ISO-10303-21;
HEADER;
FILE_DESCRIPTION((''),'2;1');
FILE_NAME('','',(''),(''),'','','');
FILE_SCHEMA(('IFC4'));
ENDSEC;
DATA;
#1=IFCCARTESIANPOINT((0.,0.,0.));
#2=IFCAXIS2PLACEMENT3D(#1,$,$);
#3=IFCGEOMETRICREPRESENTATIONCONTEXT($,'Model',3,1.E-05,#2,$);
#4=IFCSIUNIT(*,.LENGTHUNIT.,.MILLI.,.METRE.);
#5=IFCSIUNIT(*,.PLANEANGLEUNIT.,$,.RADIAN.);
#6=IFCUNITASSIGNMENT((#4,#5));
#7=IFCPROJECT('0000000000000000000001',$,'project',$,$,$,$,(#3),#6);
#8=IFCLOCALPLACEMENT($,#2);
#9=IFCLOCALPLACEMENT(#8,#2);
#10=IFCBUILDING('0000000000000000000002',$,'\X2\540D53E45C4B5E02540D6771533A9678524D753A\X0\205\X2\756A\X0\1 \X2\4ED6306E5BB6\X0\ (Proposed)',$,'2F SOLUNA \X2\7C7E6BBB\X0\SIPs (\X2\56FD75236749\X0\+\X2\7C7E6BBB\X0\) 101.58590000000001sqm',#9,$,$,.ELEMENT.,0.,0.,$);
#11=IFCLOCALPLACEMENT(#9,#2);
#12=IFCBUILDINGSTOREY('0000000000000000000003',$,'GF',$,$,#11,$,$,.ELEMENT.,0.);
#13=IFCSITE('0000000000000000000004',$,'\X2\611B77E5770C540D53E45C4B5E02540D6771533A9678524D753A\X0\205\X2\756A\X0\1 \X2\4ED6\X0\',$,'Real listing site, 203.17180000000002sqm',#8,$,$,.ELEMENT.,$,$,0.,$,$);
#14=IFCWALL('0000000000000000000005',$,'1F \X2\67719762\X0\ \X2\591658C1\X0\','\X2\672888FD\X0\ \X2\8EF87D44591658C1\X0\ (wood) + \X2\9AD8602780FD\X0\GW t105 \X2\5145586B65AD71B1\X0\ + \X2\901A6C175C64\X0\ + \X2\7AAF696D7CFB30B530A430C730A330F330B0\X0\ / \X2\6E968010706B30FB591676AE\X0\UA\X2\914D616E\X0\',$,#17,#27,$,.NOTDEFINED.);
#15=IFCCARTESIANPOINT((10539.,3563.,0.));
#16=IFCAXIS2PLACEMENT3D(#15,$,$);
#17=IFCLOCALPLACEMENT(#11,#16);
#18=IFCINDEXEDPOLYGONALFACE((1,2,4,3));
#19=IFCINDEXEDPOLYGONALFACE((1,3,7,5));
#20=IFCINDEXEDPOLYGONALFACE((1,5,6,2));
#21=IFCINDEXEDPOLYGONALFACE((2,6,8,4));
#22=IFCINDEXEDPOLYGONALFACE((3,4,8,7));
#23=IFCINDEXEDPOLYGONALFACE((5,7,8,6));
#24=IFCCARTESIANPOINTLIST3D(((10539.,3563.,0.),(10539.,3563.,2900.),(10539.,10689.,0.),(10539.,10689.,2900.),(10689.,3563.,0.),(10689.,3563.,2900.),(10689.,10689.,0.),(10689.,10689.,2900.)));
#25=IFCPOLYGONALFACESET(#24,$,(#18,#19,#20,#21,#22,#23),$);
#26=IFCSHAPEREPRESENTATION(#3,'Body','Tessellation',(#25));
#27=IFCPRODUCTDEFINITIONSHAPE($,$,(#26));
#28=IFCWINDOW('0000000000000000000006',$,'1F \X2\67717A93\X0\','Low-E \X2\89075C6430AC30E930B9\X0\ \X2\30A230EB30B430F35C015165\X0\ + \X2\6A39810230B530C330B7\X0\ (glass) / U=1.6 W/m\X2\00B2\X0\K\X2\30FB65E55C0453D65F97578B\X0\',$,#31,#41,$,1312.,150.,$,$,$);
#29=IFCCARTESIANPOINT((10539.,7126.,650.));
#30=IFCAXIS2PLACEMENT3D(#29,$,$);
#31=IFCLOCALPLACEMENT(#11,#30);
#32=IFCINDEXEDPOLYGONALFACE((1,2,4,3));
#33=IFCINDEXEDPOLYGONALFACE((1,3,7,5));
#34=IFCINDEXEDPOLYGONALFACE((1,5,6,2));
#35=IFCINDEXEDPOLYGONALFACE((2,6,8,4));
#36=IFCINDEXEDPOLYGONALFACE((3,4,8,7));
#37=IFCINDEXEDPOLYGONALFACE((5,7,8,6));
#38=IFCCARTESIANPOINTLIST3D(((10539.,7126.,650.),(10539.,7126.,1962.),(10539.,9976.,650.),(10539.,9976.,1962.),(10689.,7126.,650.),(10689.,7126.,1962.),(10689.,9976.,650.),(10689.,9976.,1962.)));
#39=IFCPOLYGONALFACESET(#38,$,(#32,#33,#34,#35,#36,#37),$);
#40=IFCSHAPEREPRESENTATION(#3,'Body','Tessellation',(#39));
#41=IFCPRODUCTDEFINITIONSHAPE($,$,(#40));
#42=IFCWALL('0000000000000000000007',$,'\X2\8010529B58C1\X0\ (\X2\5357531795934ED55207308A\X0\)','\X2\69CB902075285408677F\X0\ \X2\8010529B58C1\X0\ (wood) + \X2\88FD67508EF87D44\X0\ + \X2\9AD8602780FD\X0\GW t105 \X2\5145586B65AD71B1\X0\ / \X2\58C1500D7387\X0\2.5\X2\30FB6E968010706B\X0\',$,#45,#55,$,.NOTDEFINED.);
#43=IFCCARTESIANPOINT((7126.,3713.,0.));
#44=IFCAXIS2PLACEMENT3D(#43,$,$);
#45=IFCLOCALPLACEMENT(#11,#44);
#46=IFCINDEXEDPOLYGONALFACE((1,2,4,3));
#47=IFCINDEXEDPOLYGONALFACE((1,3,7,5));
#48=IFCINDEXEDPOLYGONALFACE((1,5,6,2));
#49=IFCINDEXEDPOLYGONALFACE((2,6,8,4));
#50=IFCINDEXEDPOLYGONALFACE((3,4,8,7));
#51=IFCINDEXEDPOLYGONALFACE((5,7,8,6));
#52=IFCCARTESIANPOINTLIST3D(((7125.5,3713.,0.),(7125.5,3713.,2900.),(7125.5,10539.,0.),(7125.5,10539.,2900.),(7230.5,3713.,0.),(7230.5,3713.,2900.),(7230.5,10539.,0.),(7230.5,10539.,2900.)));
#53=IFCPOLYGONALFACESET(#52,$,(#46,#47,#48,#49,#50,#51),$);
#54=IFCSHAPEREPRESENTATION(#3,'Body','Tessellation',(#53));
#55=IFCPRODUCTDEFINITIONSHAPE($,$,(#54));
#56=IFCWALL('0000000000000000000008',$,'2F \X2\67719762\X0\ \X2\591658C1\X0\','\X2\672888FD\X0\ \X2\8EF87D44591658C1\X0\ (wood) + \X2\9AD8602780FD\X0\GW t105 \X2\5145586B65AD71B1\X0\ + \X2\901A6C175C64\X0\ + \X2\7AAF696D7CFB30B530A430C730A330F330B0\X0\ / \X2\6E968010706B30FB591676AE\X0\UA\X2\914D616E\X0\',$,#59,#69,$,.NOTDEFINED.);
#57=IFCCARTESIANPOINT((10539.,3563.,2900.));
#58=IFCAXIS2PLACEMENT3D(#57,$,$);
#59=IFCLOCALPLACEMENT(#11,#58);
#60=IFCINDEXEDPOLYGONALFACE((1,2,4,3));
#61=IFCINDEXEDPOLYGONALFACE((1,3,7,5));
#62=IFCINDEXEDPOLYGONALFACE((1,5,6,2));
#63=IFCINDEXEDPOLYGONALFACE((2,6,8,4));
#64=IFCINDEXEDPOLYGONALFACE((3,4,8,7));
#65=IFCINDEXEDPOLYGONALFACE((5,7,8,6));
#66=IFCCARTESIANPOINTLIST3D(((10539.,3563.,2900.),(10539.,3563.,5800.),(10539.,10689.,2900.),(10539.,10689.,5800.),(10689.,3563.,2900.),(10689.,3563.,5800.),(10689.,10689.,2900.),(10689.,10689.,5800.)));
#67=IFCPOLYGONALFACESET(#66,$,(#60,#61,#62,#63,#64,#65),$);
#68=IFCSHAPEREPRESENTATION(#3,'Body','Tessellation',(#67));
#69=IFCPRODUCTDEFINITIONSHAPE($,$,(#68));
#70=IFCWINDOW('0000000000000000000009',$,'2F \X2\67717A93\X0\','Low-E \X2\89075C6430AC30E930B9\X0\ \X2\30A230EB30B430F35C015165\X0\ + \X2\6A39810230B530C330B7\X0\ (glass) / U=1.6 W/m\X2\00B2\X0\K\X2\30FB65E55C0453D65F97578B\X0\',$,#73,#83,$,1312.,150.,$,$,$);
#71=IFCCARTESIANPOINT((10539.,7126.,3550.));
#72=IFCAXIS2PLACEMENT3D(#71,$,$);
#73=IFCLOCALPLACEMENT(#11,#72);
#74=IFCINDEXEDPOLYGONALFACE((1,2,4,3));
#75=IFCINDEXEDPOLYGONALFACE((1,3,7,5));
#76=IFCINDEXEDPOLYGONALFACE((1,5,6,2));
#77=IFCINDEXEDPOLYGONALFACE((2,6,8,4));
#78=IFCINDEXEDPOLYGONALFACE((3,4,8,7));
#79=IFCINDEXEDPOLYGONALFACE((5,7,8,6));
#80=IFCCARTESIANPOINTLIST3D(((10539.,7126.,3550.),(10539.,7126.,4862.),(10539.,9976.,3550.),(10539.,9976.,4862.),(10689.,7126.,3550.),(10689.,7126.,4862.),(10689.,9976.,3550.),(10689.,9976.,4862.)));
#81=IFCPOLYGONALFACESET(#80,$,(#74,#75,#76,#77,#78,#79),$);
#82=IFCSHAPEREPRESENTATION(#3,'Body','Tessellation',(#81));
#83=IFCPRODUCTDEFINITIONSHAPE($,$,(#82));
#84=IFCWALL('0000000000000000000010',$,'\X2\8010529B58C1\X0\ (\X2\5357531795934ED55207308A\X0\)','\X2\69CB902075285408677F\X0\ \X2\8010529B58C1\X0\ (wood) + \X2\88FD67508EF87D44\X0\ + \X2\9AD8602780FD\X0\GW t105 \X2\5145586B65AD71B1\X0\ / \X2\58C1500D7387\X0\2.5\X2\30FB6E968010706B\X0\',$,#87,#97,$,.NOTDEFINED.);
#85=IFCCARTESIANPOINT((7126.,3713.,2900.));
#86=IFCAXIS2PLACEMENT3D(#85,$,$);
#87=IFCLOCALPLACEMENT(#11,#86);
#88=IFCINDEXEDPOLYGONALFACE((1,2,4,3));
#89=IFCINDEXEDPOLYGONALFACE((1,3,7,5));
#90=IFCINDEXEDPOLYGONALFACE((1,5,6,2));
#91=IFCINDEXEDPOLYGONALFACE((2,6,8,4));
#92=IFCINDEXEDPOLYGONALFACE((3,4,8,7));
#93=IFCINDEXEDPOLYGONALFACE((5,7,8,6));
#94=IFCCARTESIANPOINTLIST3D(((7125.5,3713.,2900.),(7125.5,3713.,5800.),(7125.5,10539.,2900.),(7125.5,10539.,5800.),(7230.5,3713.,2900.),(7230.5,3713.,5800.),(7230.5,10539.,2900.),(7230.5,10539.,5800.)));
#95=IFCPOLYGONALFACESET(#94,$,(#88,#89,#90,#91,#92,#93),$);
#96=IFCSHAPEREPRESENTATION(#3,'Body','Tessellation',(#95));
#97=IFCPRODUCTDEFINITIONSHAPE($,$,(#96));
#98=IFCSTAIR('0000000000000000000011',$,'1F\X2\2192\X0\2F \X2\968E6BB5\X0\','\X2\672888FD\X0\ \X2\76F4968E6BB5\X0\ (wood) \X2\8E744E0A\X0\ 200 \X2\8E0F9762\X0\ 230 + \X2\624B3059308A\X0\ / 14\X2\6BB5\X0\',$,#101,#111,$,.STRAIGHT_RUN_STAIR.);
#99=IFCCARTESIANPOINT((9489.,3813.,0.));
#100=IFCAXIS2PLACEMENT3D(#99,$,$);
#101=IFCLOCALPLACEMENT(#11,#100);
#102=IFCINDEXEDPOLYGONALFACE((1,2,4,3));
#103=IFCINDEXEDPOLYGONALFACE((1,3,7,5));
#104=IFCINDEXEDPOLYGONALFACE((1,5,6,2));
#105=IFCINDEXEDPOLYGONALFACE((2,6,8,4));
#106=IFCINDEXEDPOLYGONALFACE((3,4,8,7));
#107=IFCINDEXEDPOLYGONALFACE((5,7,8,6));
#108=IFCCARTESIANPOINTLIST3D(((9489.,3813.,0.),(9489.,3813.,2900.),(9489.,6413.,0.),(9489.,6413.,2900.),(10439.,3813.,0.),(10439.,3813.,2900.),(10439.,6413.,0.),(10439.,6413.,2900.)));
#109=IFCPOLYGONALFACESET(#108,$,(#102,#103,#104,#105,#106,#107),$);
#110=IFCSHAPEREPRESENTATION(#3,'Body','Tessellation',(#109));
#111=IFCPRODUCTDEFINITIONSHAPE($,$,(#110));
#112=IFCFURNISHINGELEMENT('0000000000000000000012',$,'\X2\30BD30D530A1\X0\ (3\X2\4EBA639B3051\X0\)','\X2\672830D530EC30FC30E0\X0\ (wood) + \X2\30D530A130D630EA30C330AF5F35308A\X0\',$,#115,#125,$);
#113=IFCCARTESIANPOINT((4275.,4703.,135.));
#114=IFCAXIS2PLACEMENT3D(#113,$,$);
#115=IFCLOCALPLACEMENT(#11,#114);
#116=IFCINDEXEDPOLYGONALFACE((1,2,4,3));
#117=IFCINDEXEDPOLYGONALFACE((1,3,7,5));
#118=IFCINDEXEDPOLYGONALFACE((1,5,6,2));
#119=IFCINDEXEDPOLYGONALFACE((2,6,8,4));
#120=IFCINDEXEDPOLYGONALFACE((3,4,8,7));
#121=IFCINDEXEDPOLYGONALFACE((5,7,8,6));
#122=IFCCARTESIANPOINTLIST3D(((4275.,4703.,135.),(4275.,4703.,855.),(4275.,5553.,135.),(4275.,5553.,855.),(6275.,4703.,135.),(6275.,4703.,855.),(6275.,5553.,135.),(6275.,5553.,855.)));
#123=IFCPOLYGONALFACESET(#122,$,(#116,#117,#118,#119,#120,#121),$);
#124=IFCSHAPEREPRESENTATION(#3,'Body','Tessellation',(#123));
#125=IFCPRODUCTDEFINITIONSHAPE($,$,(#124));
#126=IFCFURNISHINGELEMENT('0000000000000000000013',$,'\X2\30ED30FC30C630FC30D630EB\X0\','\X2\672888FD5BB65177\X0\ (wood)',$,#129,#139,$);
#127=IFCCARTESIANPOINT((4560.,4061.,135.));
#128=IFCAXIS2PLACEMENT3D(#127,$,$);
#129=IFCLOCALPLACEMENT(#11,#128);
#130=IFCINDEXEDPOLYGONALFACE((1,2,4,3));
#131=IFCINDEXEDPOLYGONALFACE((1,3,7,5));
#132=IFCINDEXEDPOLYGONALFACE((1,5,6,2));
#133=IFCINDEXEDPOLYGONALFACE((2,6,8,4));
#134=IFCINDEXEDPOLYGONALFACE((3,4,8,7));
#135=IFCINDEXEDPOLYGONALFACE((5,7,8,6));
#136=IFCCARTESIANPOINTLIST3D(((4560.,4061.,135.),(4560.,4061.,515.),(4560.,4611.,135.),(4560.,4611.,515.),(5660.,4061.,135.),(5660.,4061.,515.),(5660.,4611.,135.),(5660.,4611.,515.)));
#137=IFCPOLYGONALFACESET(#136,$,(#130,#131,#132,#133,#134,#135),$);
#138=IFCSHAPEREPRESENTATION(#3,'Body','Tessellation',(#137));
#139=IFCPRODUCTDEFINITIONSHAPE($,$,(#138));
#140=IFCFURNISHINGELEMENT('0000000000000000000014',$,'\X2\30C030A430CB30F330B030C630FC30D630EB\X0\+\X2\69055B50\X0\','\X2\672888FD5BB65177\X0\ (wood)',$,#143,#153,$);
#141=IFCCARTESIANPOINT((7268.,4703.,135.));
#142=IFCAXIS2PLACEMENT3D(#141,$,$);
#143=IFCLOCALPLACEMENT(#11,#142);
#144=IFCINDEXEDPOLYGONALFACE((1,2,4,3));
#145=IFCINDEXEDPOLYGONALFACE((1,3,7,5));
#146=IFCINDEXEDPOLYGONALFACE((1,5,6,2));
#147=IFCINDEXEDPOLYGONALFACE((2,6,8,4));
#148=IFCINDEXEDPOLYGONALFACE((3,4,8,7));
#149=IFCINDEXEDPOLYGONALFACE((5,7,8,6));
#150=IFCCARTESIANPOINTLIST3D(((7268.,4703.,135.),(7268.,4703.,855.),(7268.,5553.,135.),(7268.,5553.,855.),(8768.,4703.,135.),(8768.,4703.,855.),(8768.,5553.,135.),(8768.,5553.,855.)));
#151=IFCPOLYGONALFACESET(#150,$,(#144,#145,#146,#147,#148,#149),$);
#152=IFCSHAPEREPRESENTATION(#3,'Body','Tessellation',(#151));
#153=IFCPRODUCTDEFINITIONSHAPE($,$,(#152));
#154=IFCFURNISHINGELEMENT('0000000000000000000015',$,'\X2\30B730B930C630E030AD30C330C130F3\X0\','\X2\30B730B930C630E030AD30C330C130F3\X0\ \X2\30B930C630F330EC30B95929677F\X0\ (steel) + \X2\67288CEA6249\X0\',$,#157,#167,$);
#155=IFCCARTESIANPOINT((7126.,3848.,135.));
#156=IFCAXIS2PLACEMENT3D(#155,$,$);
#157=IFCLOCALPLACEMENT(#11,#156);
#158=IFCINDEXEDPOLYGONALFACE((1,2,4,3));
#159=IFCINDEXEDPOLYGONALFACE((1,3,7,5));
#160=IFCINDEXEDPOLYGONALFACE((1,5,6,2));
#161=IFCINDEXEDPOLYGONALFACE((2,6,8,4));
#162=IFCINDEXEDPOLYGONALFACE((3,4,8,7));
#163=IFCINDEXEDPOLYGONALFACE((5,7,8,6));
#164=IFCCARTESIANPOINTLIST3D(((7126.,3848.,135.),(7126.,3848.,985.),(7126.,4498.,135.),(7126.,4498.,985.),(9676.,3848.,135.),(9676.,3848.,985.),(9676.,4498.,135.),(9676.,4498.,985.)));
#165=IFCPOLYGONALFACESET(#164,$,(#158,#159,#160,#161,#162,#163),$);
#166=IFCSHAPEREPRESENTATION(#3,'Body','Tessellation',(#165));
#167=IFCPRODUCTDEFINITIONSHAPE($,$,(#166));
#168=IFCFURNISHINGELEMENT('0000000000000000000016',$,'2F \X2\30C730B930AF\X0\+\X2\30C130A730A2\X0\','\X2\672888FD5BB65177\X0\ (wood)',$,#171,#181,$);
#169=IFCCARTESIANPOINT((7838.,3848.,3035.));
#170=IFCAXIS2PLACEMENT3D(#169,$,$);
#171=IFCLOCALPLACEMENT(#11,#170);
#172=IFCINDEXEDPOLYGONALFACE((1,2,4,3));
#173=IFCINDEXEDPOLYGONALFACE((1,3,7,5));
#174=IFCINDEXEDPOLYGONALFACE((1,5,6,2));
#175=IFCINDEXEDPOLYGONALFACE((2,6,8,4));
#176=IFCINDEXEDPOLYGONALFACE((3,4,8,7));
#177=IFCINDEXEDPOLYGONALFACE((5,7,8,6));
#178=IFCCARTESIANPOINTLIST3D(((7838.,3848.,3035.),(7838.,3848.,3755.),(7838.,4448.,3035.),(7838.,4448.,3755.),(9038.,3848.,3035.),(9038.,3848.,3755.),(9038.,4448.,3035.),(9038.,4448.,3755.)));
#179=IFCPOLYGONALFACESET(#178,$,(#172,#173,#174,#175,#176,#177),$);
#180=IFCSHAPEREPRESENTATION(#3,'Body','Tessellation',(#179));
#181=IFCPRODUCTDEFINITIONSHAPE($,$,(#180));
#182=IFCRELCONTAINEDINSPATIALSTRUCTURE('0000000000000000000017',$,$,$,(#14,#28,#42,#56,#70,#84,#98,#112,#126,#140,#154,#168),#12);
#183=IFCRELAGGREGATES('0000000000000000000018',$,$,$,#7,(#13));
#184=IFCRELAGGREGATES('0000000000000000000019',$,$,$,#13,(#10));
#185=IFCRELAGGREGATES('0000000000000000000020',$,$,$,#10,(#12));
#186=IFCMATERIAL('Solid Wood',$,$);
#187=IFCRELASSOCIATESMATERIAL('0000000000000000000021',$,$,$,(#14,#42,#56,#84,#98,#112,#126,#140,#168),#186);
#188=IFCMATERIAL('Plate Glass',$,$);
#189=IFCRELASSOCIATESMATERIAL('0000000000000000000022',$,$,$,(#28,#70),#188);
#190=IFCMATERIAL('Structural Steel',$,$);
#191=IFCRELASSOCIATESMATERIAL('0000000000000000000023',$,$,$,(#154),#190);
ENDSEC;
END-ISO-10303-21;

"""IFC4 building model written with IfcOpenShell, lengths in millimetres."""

from ifc_helpers import new_model, si_unit, frame, frame_2d, origin, place, context, project, spatial, rectangle, extrude, material, element, fill, save


model = new_model("IFC4")

# Units and contexts
model_context = context("Model", 3, precision=1e-05, world=origin())
ifc_project = project(units=[si_unit("LENGTHUNIT", "METRE", prefix="MILLI"), si_unit("PLANEANGLEUNIT", "RADIAN")], contexts=[model_context])

# Site, building, storey
site_placement = place(None, origin())
site = spatial("IfcSite", under=ifc_project, at=site_placement, Name="愛知県名古屋市名東区陸前町205番1 他", ObjectType="Real listing site, 203.17180000000002sqm", CompositionType="ELEMENT", RefElevation=0.0)
building_placement = place(site_placement, origin())
building = spatial("IfcBuilding", under=site, at=building_placement, Name="名古屋市名東区陸前町205番1 他の家 (Proposed)", ObjectType="2F SOLUNA 籾殻SIPs (国産杉+籾殻) 101.58590000000001sqm", CompositionType="ELEMENT", ElevationOfRefHeight=0.0, ElevationOfTerrain=0.0)
storey_placement = place(building_placement, origin())
storey = spatial("IfcBuildingStorey", under=building, at=storey_placement, Name="GF", CompositionType="ELEMENT", Elevation=0.0)

# Wall, opening, window
ifc_material_1 = material(Name="Solid Wood")
wall_1_placement = place(storey_placement, frame((10539.0, 3563.0, 0.0)))
wall_1 = element("IfcWall", 1, at=wall_1_placement, inside=storey, material=ifc_material_1, Name="1F 東面 外壁", Description="木製 軸組外壁 (wood) + 高性能GW t105 充填断熱 + 通気層 + 窯業系サイディング / 準耐火・外皮UA配慮", PredefinedType="NOTDEFINED", context=model_context, shape_type="SweptSolid", body=[
    extrude(rectangle(XDim=150.0, YDim=7126.0, at=frame_2d((75.0, 3563.0))), frame((10539.0, 3563.0, 0.0)), (0.0, 0.0, 1.0), 2900.0),
])
opening_1_placement = place(storey_placement, frame((10539.0, 7126.0, 650.0)))
opening_1 = element("IfcOpeningElement", 2, at=opening_1_placement, cuts=wall_1, PredefinedType="NOTDEFINED", context=model_context, shape_type="SweptSolid", body=[
    extrude(rectangle(XDim=150.0, YDim=2850.0, at=frame_2d((75.0, 1425.0))), frame((10539.0, 7126.0, 650.0)), (0.0, 0.0, 1.0), 1312.0),
])
ifc_material_2 = material(Name="Plate Glass")
window_1_placement = place(storey_placement, frame((10539.0, 7126.0, 650.0)))
window_1 = element("IfcWindow", 3, at=window_1_placement, inside=storey, material=ifc_material_2, Name="1F 東窓", Description="Low-E 複層ガラス アルゴン封入 + 樹脂サッシ (glass) / U=1.6 W/m²K・日射取得型", OverallHeight=1312.0, OverallWidth=150.0, context=model_context, shape_type="SweptSolid", body=[
    extrude(rectangle(XDim=150.0, YDim=2850.0, at=frame_2d((75.0, 1425.0))), frame((10539.0, 7126.0, 650.0)), (0.0, 0.0, 1.0), 1312.0),
])
fill(opening_1, window_1)

# Wall
wall_2_placement = place(storey_placement, frame((7126.0, 3713.0, 0.0)))
element("IfcWall", 4, at=wall_2_placement, inside=storey, material=ifc_material_1, Name="耐力壁 (南北間仕切り)", Description="構造用合板 耐力壁 (wood) + 製材軸組 + 高性能GW t105 充填断熱 / 壁倍率2.5・準耐火", PredefinedType="NOTDEFINED", context=model_context, shape_type="SweptSolid", body=[
    extrude(rectangle(XDim=105.0, YDim=6826.0, at=frame_2d((52.0, 3413.0))), frame((7126.0, 3713.0, 0.0)), (0.0, 0.0, 1.0), 2900.0),
])

# Wall, opening, window
wall_3_placement = place(storey_placement, frame((10539.0, 3563.0, 2900.0)))
wall_3 = element("IfcWall", 5, at=wall_3_placement, inside=storey, material=ifc_material_1, Name="2F 東面 外壁", Description="木製 軸組外壁 (wood) + 高性能GW t105 充填断熱 + 通気層 + 窯業系サイディング / 準耐火・外皮UA配慮", PredefinedType="NOTDEFINED", context=model_context, shape_type="SweptSolid", body=[
    extrude(rectangle(XDim=150.0, YDim=7126.0, at=frame_2d((75.0, 3563.0))), frame((10539.0, 3563.0, 2900.0)), (0.0, 0.0, 1.0), 2900.0),
])
opening_2_placement = place(storey_placement, frame((10539.0, 7126.0, 3550.0)))
opening_2 = element("IfcOpeningElement", 6, at=opening_2_placement, cuts=wall_3, PredefinedType="NOTDEFINED", context=model_context, shape_type="SweptSolid", body=[
    extrude(rectangle(XDim=150.0, YDim=2850.0, at=frame_2d((75.0, 1425.0))), frame((10539.0, 7126.0, 3550.0)), (0.0, 0.0, 1.0), 1312.0),
])
window_2_placement = place(storey_placement, frame((10539.0, 7126.0, 3550.0)))
window_2 = element("IfcWindow", 7, at=window_2_placement, inside=storey, material=ifc_material_2, Name="2F 東窓", Description="Low-E 複層ガラス アルゴン封入 + 樹脂サッシ (glass) / U=1.6 W/m²K・日射取得型", OverallHeight=1312.0, OverallWidth=150.0, context=model_context, shape_type="SweptSolid", body=[
    extrude(rectangle(XDim=150.0, YDim=2850.0, at=frame_2d((75.0, 1425.0))), frame((10539.0, 7126.0, 3550.0)), (0.0, 0.0, 1.0), 1312.0),
])
fill(opening_2, window_2)

# Wall
wall_4_placement = place(storey_placement, frame((7126.0, 3713.0, 2900.0)))
element("IfcWall", 8, at=wall_4_placement, inside=storey, material=ifc_material_1, Name="耐力壁 (南北間仕切り)", Description="構造用合板 耐力壁 (wood) + 製材軸組 + 高性能GW t105 充填断熱 / 壁倍率2.5・準耐火", PredefinedType="NOTDEFINED", context=model_context, shape_type="SweptSolid", body=[
    extrude(rectangle(XDim=105.0, YDim=6826.0, at=frame_2d((52.0, 3413.0))), frame((7126.0, 3713.0, 2900.0)), (0.0, 0.0, 1.0), 2900.0),
])

# Stair
stair_placement = place(storey_placement, frame((9489.0, 3813.0, 0.0)))
element("IfcStair", 9, at=stair_placement, inside=storey, material=ifc_material_1, Name="1F→2F 階段", Description="木製 直階段 (wood) 蹴上 200 踏面 230 + 手すり / 14段", PredefinedType="STRAIGHT_RUN_STAIR", context=model_context, shape_type="SweptSolid", body=[
    extrude(rectangle(XDim=950.0, YDim=2600.0, at=frame_2d((475.0, 1300.0))), frame((9489.0, 3813.0, 0.0)), (0.0, 0.0, 1.0), 2900.0),
])

# Furnishing elements
furnishing_1_placement = place(storey_placement, frame((4275.0, 4703.0, 135.0)))
element("IfcFurnishingElement", 10, at=furnishing_1_placement, inside=storey, material=ifc_material_1, Name="ソファ (3人掛け)", Description="木フレーム (wood) + ファブリック張り", context=model_context, shape_type="SweptSolid", body=[
    extrude(rectangle(XDim=2000.0, YDim=850.0, at=frame_2d((1000.0, 425.0))), frame((4275.0, 4703.0, 135.0)), (0.0, 0.0, 1.0), 720.0),
])
furnishing_2_placement = place(storey_placement, frame((4560.0, 4061.0, 135.0)))
element("IfcFurnishingElement", 11, at=furnishing_2_placement, inside=storey, material=ifc_material_1, Name="ローテーブル", Description="木製家具 (wood)", context=model_context, shape_type="SweptSolid", body=[
    extrude(rectangle(XDim=1100.0, YDim=550.0, at=frame_2d((550.0, 275.0))), frame((4560.0, 4061.0, 135.0)), (0.0, 0.0, 1.0), 380.0),
])
furnishing_3_placement = place(storey_placement, frame((7268.0, 4703.0, 135.0)))
element("IfcFurnishingElement", 12, at=furnishing_3_placement, inside=storey, material=ifc_material_1, Name="ダイニングテーブル+椅子", Description="木製家具 (wood)", context=model_context, shape_type="SweptSolid", body=[
    extrude(rectangle(XDim=1500.0, YDim=850.0, at=frame_2d((750.0, 425.0))), frame((7268.0, 4703.0, 135.0)), (0.0, 0.0, 1.0), 720.0),
])
ifc_material_3 = material(Name="Structural Steel")
furnishing_4_placement = place(storey_placement, frame((7126.0, 3848.0, 135.0)))
element("IfcFurnishingElement", 13, at=furnishing_4_placement, inside=storey, material=ifc_material_3, Name="システムキッチン", Description="システムキッチン ステンレス天板 (steel) + 木質扉", context=model_context, shape_type="SweptSolid", body=[
    extrude(rectangle(XDim=2550.0, YDim=650.0, at=frame_2d((1275.0, 325.0))), frame((7126.0, 3848.0, 135.0)), (0.0, 0.0, 1.0), 850.0),
])
furnishing_5_placement = place(storey_placement, frame((7838.0, 3848.0, 3035.0)))
element("IfcFurnishingElement", 14, at=furnishing_5_placement, inside=storey, material=ifc_material_1, Name="2F デスク+チェア", Description="木製家具 (wood)", context=model_context, shape_type="SweptSolid", body=[
    extrude(rectangle(XDim=1200.0, YDim=600.0, at=frame_2d((600.0, 300.0))), frame((7838.0, 3848.0, 3035.0)), (0.0, 0.0, 1.0), 720.0),
])

save(model, "model.ifc")
